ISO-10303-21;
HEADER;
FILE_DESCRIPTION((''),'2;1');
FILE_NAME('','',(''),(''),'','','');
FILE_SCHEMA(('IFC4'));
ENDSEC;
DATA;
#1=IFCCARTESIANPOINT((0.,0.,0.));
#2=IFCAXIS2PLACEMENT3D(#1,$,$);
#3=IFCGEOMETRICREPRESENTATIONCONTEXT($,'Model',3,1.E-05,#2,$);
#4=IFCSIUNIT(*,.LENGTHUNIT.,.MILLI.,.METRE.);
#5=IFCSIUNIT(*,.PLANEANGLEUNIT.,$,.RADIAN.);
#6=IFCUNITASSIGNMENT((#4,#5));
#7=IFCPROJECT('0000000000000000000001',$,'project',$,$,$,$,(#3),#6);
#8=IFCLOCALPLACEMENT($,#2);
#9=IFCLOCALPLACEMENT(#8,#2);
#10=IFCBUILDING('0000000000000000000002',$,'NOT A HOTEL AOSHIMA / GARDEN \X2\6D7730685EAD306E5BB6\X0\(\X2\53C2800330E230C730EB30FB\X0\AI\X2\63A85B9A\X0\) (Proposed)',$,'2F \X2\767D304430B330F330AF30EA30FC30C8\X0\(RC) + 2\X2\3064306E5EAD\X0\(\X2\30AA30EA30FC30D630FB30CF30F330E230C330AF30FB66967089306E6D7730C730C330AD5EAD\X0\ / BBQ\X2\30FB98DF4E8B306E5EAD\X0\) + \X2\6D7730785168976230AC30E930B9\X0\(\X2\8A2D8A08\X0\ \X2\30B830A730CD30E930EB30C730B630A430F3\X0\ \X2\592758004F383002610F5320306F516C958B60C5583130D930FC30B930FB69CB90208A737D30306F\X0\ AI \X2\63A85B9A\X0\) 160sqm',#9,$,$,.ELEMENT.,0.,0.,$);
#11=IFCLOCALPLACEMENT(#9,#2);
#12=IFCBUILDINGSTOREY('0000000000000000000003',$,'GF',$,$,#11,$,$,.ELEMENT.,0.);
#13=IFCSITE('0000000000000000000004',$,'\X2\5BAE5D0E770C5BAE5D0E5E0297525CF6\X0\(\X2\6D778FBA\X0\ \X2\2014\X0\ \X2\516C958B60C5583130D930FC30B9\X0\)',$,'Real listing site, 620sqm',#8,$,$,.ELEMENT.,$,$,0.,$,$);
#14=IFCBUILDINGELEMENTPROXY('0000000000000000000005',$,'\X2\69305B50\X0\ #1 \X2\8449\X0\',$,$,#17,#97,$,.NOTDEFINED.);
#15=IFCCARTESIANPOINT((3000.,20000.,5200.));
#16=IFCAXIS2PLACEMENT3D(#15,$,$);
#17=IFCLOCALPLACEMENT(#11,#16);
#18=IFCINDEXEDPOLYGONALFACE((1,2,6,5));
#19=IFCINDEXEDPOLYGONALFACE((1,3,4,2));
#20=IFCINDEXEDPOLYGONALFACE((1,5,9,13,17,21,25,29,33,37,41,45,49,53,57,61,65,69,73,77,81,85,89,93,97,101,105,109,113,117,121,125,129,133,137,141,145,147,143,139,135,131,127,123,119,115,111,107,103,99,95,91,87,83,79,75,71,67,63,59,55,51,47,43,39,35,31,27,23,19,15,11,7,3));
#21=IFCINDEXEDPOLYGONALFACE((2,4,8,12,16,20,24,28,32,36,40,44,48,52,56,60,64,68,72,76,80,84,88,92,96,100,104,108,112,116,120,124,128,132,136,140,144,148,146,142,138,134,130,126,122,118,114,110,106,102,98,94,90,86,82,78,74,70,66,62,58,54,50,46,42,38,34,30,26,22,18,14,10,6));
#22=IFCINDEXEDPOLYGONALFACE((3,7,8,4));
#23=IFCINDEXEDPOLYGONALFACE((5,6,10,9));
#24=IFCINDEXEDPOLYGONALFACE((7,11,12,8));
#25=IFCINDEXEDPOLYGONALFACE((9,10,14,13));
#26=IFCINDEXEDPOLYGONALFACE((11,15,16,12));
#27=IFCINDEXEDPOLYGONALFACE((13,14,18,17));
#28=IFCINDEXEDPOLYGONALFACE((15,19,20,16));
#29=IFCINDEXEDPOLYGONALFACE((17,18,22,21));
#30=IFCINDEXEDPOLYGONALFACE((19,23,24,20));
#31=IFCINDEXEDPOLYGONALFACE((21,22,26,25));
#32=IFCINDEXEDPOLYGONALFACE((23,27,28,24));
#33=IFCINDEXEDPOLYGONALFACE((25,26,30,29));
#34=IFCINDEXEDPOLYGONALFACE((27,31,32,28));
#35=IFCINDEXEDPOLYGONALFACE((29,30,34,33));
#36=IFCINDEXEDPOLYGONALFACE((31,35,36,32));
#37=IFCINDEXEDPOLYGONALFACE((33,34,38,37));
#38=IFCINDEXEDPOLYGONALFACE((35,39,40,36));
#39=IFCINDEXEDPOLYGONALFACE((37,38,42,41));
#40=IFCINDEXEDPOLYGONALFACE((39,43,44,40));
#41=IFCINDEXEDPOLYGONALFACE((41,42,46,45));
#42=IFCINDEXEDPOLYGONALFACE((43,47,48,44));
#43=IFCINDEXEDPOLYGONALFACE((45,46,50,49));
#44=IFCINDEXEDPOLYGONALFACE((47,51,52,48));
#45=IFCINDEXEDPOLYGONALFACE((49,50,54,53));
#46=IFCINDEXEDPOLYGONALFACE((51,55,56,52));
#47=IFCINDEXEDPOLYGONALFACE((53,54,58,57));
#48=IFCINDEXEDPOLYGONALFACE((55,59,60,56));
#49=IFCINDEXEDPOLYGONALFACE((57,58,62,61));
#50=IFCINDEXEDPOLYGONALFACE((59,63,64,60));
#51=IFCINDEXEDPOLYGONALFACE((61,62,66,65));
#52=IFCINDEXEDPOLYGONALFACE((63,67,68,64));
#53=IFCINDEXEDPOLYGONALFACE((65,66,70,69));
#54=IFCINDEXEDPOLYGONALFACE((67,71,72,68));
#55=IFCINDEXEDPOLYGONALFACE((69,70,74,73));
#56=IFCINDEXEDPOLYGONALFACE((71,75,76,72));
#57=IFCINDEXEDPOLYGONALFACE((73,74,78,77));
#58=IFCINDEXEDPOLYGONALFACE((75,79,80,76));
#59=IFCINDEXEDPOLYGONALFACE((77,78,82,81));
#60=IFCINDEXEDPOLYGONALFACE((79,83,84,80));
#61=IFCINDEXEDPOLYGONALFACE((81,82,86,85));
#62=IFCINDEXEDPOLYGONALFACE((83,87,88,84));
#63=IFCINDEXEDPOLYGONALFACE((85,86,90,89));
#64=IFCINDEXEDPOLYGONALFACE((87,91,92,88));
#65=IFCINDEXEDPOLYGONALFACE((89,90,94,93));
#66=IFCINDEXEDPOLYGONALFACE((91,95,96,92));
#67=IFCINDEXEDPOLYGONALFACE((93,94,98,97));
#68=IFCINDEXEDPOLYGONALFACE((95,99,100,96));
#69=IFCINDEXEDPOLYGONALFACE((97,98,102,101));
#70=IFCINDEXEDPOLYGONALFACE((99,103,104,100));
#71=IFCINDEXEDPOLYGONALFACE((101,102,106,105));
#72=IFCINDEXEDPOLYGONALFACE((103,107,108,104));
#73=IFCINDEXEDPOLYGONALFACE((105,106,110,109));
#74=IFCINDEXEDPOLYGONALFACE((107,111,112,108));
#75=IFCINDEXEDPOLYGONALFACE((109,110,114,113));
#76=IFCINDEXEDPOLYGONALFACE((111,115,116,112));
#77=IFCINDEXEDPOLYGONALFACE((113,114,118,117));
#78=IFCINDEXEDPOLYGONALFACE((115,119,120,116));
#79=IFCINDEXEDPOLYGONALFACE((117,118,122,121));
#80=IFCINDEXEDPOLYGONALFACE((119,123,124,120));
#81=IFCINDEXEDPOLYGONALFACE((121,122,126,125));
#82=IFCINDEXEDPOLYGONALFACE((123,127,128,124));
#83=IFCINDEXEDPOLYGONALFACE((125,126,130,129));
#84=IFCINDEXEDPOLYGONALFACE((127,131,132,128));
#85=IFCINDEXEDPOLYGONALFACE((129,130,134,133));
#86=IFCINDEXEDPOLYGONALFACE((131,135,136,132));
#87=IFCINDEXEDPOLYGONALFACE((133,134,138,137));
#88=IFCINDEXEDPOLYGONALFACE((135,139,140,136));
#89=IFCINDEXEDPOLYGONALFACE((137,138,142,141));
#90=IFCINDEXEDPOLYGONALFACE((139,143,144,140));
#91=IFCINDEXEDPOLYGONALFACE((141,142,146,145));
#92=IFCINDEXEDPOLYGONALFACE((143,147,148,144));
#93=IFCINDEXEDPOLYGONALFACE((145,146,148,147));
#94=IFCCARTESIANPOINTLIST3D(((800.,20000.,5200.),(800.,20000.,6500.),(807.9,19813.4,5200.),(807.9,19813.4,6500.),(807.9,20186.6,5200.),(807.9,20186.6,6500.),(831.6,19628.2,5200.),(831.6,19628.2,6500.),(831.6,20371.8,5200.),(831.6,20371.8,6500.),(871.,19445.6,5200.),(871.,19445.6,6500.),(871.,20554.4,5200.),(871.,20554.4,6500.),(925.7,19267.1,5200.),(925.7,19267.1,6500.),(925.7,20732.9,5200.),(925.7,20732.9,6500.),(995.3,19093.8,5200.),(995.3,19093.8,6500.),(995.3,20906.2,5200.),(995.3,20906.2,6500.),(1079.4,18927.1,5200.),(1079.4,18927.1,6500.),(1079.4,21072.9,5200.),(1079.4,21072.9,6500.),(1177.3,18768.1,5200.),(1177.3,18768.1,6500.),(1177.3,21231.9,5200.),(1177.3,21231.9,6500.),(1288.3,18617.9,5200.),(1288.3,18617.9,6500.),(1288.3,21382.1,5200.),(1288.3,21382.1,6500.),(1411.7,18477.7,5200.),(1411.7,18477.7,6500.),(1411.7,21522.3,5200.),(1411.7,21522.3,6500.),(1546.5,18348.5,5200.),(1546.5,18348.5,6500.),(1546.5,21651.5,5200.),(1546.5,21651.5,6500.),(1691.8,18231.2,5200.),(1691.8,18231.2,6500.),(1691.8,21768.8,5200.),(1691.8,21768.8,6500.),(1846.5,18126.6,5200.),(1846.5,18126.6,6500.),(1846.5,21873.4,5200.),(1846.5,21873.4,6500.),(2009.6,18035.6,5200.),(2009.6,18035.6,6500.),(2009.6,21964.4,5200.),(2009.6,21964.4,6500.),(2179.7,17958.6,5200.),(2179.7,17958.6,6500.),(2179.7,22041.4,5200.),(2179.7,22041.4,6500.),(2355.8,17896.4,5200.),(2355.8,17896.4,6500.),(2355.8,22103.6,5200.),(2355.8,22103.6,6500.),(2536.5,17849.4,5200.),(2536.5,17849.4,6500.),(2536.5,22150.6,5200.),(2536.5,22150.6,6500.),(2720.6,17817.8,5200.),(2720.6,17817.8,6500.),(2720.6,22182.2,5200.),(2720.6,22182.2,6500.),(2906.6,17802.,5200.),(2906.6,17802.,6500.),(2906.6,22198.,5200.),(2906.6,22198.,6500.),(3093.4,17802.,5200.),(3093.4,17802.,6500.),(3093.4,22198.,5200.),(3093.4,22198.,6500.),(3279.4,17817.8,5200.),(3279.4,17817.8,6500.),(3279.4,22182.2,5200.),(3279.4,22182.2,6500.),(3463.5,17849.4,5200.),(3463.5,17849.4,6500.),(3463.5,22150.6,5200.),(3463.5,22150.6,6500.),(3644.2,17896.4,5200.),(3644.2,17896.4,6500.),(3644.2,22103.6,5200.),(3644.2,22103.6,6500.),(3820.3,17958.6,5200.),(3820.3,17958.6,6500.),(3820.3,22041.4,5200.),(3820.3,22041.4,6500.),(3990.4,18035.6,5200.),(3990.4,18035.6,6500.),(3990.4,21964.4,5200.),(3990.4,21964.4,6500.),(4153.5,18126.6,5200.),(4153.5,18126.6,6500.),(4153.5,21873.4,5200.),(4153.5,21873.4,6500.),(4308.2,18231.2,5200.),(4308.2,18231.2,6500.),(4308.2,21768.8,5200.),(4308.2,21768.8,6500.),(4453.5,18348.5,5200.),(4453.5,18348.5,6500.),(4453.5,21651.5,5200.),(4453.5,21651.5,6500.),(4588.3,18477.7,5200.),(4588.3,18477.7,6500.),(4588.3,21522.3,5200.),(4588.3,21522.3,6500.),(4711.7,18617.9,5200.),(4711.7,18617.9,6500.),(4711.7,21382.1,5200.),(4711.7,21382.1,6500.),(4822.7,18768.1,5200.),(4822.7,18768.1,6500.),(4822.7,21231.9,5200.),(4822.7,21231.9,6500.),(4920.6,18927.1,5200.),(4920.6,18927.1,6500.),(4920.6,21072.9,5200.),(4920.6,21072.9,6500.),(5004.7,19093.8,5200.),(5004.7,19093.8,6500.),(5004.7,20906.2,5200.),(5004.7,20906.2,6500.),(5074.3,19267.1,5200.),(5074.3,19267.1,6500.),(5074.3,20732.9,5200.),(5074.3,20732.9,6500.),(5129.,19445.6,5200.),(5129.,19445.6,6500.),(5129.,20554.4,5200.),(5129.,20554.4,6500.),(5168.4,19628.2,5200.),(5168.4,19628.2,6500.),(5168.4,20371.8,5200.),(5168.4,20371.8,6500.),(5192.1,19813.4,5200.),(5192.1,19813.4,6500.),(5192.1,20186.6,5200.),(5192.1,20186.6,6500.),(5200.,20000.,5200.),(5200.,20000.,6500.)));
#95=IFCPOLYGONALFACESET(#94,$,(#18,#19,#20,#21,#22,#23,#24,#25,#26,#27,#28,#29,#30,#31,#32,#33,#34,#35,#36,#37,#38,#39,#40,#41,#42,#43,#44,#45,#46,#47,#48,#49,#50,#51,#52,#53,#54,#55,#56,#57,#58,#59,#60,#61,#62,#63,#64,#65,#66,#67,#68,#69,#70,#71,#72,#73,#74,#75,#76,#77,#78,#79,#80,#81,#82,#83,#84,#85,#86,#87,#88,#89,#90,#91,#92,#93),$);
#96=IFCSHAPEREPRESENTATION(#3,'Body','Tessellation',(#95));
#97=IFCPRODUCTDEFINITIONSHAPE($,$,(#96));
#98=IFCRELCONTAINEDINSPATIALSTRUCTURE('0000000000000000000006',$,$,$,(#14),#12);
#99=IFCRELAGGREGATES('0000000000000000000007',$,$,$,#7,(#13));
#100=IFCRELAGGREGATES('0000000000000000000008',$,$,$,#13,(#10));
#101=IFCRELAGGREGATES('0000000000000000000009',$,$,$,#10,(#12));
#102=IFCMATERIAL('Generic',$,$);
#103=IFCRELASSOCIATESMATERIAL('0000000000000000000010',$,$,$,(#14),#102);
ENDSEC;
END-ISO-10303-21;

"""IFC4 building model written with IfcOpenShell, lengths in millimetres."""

from ifc_helpers import new_model, si_unit, frame, origin, origin_2d, place, context, project, spatial, circle, extrude, material, element, save


model = new_model("IFC4")

# Units and contexts
model_context = context("Model", 3, precision=1e-05, world=origin())
ifc_project = project(units=[si_unit("LENGTHUNIT", "METRE", prefix="MILLI"), si_unit("PLANEANGLEUNIT", "RADIAN")], contexts=[model_context])

# Site, building, storey
site_placement = place(None, origin())
site = spatial("IfcSite", under=ifc_project, at=site_placement, Name="宮崎県宮崎市青島(海辺 — 公開情報ベース)", ObjectType="Real listing site, 620sqm", CompositionType="ELEMENT", RefElevation=0.0)
building_placement = place(site_placement, origin())
building = spatial("IfcBuilding", under=site, at=building_placement, Name="NOT A HOTEL AOSHIMA / GARDEN 海と庭の家(参考モデル・AI推定) (Proposed)", ObjectType="2F 白いコンクリート(RC) + 2つの庭(オリーブ・ハンモック・暖炉の海デッキ庭 / BBQ・食事の庭) + 海へ全面ガラス(設計 ジェネラルデザイン 大堀伸。意匠は公開情報ベース・構造詳細は AI 推定) 160sqm", CompositionType="ELEMENT", ElevationOfRefHeight=0.0, ElevationOfTerrain=0.0)
storey_placement = place(building_placement, origin())
storey = spatial("IfcBuildingStorey", under=building, at=storey_placement, Name="GF", CompositionType="ELEMENT", Elevation=0.0)

# Shared definitions
ifc_material_1 = material(Name="Generic")

# Building element proxy
proxy_1_placement = place(storey_placement, frame((3000.0, 20000.0, 5200.0)))
element("IfcBuildingElementProxy", 1, at=proxy_1_placement, inside=storey, material=ifc_material_1, Name="椰子 #1 葉", PredefinedType="NOTDEFINED", context=model_context, shape_type="SweptSolid", body=[
    extrude(circle(Radius=2200.0, at=origin_2d()), frame((3000.0, 20000.0, 5200.0)), (0.0, 0.0, 1.0), 1300.0),
])

save(model, "model.ifc")
